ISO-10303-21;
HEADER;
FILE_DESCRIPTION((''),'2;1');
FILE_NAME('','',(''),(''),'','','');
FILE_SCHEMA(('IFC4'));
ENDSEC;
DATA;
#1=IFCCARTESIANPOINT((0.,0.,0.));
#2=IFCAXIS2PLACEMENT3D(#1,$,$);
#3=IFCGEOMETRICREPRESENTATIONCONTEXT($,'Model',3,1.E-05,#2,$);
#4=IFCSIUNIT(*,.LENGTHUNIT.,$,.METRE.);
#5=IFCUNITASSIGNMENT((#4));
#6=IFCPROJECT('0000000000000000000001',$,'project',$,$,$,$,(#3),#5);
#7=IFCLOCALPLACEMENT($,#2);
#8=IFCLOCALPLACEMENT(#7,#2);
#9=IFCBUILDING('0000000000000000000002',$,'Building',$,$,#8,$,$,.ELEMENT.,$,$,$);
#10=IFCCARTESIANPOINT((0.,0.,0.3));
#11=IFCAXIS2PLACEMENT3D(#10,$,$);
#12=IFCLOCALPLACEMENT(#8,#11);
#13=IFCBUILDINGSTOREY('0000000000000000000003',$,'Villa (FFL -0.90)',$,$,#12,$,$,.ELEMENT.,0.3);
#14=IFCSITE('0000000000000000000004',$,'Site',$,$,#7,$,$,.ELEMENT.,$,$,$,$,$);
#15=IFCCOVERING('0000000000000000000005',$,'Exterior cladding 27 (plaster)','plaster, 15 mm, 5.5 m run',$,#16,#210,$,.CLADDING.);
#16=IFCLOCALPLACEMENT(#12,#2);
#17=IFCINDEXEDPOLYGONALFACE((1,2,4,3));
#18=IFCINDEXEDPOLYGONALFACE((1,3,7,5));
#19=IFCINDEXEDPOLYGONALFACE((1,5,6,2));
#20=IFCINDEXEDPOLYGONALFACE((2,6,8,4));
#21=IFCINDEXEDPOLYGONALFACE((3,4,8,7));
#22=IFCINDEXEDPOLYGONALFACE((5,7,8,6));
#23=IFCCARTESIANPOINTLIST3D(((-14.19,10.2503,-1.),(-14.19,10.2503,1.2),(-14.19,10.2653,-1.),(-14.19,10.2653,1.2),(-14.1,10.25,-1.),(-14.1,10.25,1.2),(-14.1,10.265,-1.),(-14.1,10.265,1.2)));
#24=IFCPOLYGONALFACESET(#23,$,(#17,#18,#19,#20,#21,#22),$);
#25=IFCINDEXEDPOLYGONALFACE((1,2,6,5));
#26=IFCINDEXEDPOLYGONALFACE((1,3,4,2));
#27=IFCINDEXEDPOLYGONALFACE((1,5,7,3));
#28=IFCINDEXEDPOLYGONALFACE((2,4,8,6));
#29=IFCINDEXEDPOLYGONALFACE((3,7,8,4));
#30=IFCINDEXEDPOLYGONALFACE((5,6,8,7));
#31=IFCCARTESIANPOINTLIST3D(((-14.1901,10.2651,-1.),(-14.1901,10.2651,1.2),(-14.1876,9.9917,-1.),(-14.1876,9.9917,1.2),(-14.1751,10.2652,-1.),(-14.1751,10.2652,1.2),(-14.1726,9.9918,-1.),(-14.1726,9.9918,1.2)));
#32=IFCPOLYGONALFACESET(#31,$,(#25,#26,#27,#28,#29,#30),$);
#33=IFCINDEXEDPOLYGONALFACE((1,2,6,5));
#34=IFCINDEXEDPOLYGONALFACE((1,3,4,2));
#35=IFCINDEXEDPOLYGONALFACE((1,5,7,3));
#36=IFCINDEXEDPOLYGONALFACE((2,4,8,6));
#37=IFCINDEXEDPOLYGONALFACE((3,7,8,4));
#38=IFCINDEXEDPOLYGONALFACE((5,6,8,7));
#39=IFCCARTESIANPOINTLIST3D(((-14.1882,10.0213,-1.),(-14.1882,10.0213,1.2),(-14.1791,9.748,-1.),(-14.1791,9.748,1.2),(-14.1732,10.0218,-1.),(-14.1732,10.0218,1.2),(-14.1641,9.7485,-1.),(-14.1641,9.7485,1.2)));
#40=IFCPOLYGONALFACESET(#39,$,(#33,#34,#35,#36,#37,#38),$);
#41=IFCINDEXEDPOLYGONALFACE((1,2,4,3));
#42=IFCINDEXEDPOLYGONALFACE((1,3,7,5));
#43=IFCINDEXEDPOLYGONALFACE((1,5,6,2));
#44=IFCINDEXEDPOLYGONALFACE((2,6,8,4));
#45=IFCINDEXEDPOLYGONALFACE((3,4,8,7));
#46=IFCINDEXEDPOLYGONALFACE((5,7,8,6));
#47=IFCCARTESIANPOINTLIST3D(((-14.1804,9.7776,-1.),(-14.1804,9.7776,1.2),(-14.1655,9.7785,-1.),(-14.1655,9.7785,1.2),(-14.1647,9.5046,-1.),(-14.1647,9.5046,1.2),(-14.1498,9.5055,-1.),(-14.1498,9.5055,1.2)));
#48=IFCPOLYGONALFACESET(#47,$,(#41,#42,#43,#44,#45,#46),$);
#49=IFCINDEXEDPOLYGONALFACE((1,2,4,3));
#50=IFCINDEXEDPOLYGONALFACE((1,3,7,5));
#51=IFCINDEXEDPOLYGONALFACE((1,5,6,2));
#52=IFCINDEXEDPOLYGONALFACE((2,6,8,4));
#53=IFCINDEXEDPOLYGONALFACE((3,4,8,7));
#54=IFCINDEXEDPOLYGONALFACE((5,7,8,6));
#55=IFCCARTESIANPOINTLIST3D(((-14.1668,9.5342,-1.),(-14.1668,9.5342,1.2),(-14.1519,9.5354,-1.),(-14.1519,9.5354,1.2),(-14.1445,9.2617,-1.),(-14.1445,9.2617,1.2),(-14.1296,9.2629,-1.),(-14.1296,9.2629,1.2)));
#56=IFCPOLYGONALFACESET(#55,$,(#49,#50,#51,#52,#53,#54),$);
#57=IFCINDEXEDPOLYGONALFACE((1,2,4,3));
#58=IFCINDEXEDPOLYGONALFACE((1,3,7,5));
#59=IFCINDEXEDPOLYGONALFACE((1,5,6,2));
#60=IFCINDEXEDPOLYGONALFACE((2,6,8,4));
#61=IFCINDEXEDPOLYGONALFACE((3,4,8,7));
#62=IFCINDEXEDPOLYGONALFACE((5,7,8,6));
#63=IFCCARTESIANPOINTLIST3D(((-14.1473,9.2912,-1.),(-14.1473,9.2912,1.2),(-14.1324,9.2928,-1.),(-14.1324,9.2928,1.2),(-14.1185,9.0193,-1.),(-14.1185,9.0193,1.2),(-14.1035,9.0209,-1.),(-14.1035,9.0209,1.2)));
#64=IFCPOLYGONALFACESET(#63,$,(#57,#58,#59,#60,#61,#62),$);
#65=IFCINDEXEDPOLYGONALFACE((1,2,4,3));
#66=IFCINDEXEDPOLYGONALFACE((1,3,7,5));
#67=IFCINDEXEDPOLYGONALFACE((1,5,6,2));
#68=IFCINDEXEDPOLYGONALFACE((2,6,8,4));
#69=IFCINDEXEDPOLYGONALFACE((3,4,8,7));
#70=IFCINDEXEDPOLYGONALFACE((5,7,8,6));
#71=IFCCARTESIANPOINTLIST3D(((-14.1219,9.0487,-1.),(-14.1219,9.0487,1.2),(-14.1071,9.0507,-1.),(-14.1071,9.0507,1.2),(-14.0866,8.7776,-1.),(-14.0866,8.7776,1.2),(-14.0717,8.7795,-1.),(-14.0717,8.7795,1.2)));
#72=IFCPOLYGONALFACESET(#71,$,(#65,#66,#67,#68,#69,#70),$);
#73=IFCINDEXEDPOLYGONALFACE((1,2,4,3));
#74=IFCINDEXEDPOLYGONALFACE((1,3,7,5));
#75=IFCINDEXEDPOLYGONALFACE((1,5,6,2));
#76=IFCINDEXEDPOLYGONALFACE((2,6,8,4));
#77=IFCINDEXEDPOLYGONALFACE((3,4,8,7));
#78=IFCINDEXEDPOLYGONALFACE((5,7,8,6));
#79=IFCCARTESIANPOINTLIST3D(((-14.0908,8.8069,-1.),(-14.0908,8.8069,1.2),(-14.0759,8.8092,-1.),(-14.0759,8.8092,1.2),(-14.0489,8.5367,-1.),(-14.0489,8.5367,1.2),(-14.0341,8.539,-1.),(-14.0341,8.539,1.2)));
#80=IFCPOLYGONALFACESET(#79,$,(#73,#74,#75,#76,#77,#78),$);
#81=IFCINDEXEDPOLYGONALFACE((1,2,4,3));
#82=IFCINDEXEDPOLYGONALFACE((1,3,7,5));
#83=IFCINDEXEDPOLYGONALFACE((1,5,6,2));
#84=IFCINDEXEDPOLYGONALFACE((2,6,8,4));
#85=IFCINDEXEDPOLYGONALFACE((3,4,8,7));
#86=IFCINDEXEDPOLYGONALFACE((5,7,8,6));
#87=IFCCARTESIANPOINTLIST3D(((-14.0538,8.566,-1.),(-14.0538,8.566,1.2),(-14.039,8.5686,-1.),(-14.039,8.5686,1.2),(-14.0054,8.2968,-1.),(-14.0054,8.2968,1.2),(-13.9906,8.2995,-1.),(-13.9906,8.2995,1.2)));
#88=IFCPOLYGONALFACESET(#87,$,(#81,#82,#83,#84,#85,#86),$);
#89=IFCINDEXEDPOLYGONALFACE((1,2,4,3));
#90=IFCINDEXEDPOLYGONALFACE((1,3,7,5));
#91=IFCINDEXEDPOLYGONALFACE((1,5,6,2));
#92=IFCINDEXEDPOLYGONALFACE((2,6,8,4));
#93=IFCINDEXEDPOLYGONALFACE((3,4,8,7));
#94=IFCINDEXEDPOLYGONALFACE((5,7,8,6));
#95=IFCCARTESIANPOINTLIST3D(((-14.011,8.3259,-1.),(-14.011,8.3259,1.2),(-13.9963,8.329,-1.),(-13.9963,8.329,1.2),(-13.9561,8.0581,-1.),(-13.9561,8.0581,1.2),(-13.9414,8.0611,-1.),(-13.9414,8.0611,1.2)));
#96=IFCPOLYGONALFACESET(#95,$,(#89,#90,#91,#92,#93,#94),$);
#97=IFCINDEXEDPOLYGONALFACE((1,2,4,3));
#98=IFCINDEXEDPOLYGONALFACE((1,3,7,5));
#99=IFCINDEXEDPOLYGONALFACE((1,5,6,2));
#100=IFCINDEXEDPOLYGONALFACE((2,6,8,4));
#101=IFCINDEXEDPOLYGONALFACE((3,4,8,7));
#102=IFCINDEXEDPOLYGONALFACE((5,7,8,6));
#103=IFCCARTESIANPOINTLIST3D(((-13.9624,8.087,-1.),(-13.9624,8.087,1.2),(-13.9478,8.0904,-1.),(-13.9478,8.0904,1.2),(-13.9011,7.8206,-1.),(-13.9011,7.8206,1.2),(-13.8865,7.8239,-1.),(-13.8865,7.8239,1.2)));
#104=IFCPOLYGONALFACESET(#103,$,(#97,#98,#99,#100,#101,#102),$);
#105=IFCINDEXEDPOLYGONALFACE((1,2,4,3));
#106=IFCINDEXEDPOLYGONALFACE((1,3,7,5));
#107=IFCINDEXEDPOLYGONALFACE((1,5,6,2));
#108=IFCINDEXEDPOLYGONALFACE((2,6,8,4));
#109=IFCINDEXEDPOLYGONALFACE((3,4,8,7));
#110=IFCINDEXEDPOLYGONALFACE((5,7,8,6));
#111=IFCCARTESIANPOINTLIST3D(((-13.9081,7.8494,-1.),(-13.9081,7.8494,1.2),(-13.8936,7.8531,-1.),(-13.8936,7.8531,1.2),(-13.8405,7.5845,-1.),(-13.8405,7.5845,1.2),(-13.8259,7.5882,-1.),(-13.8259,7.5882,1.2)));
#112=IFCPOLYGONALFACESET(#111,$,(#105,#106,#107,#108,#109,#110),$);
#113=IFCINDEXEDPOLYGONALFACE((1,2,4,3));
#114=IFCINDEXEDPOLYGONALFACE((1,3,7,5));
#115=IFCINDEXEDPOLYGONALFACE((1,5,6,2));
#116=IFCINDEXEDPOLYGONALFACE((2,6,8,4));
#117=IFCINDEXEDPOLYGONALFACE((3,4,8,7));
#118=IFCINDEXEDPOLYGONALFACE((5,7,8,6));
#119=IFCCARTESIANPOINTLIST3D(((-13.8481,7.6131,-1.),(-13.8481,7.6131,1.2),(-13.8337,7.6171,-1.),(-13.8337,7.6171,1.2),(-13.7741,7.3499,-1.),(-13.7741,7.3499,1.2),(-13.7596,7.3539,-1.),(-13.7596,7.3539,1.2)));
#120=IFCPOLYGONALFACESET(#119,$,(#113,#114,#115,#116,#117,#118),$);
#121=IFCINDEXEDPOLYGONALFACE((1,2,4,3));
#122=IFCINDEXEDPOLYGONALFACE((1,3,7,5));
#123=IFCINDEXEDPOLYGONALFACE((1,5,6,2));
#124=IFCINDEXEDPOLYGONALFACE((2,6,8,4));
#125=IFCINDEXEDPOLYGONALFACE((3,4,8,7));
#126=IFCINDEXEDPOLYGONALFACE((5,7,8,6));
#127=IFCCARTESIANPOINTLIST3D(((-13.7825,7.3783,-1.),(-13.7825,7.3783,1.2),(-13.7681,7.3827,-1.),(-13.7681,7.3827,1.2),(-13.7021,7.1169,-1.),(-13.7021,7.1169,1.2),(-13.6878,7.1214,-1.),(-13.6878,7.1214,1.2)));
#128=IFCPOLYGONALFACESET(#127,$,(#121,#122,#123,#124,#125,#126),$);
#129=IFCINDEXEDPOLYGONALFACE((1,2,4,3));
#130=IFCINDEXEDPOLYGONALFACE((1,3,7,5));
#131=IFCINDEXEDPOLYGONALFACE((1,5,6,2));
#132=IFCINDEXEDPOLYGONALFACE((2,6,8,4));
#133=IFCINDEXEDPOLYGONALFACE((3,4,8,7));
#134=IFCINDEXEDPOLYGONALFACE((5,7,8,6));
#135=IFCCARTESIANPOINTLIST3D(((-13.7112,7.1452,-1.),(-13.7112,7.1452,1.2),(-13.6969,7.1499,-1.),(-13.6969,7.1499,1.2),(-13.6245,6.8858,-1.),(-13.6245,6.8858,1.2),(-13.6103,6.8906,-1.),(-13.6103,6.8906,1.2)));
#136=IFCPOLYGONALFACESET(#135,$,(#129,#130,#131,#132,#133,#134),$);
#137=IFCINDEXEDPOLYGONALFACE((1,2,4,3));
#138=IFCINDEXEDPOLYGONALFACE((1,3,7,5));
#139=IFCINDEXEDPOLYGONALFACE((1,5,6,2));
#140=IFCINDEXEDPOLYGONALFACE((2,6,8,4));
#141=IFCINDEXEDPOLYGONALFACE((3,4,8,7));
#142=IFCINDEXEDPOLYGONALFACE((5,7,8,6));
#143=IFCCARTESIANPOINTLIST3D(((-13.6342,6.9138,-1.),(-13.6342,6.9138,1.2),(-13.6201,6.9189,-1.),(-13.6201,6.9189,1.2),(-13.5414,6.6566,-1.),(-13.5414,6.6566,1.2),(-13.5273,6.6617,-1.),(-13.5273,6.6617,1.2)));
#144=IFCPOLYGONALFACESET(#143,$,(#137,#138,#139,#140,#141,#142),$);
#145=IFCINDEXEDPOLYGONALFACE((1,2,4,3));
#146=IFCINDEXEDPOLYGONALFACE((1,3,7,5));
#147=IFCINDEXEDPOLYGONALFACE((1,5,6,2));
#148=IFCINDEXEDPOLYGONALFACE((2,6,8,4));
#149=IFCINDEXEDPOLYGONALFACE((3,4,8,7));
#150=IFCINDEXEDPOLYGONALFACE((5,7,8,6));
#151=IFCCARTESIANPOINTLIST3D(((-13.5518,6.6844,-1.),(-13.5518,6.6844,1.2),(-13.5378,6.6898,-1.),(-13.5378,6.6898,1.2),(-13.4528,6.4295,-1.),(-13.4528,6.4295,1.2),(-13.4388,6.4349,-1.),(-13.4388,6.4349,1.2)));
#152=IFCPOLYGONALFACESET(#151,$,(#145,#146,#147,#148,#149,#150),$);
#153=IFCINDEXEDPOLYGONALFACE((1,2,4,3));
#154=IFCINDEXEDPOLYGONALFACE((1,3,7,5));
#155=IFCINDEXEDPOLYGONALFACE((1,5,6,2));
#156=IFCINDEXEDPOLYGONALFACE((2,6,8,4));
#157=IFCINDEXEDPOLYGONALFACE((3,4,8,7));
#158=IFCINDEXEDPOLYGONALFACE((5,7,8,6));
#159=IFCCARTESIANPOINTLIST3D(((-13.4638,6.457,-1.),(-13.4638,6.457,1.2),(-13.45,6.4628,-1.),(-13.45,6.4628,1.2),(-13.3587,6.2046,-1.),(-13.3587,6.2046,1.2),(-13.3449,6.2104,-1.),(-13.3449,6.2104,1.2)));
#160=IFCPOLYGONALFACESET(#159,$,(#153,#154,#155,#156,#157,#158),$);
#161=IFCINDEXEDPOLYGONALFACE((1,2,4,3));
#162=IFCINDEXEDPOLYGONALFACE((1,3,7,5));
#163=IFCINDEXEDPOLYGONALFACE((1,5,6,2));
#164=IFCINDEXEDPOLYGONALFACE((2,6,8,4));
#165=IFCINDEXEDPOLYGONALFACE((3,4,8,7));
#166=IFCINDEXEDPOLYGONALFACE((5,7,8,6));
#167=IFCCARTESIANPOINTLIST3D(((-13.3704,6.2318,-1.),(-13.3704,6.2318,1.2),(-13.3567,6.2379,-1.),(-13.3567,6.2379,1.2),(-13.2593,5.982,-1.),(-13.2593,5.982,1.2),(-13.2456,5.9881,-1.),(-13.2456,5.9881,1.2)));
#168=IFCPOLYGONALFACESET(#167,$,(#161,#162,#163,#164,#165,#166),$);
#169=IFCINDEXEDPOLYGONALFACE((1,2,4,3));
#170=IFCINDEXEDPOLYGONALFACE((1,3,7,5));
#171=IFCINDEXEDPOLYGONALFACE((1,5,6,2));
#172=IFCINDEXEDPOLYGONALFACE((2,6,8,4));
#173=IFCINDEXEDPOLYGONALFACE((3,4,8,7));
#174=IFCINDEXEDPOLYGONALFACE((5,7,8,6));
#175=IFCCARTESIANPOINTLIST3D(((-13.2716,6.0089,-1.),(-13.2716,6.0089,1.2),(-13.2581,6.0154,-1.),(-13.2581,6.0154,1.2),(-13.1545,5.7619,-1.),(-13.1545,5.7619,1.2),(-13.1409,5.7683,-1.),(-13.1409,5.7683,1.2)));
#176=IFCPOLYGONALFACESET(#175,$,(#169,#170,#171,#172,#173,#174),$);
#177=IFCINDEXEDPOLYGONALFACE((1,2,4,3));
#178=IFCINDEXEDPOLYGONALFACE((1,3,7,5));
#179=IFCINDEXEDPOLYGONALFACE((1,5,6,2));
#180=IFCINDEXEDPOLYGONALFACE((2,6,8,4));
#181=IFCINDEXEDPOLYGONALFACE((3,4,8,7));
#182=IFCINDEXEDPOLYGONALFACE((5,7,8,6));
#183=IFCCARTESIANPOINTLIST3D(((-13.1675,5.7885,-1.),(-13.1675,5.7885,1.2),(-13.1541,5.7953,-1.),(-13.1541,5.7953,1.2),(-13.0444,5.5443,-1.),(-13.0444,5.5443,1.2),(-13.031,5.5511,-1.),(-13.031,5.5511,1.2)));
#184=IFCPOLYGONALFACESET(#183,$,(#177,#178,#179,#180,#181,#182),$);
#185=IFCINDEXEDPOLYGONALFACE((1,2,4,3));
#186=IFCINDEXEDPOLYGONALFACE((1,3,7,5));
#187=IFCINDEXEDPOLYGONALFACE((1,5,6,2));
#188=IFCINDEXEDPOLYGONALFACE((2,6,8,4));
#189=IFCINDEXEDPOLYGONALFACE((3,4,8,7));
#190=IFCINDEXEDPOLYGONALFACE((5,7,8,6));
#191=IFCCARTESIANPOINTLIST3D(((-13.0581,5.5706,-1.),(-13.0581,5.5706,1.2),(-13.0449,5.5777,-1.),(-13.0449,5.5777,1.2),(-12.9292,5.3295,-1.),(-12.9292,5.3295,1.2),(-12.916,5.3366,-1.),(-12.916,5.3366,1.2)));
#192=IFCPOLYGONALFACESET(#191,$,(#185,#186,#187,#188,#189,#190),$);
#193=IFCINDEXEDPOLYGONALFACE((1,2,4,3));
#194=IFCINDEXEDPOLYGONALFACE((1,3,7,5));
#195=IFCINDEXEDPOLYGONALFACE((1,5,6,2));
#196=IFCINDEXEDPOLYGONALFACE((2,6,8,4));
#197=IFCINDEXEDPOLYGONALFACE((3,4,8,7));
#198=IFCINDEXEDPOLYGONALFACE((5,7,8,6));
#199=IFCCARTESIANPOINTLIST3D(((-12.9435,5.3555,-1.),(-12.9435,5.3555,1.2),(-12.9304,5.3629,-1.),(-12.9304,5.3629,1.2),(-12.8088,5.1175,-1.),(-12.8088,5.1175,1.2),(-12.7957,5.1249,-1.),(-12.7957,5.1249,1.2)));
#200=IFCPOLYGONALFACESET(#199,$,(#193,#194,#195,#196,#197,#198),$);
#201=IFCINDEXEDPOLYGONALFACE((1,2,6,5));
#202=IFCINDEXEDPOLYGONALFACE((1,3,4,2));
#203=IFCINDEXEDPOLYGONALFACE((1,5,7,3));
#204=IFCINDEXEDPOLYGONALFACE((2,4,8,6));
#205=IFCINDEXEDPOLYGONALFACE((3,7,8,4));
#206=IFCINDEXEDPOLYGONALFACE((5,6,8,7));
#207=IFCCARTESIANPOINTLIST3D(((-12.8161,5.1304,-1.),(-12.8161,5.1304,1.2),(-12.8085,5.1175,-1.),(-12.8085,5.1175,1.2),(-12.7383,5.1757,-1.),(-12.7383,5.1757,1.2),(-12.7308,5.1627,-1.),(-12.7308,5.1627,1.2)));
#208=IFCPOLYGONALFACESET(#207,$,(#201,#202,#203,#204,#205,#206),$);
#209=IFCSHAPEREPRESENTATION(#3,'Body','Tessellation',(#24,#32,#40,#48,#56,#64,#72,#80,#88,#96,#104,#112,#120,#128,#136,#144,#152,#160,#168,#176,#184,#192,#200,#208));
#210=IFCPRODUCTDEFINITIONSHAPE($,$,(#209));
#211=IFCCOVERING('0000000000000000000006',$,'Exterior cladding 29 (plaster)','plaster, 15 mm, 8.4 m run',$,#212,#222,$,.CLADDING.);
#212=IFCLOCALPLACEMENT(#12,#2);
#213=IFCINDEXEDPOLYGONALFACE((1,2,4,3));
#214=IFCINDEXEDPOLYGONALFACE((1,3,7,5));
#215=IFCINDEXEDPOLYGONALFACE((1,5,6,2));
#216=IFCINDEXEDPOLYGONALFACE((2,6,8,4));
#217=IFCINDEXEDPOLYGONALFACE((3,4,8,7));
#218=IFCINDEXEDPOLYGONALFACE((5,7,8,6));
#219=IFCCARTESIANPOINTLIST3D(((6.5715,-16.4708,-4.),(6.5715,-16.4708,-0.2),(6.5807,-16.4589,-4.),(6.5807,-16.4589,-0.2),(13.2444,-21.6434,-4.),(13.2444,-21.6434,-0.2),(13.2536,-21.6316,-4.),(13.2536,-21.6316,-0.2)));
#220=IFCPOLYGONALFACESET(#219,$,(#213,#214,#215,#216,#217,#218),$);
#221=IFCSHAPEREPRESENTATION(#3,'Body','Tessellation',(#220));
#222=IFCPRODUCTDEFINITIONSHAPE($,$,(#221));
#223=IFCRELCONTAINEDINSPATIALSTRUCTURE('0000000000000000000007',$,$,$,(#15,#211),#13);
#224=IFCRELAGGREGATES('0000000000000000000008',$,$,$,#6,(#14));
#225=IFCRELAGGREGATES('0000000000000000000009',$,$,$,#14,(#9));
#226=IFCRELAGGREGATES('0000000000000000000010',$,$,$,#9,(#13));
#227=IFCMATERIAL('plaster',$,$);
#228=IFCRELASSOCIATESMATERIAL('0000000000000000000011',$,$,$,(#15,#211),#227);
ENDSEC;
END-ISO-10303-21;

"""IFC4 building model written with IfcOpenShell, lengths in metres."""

from ifc_helpers import new_model, si_unit, frame, origin, origin_with_axes, place, context, project, spatial, polyline, outline, extrude, material, element, save


model = new_model("IFC4")

# Units and contexts
model_context = context("Model", 3, precision=1e-05, world=origin())
ifc_project = project(units=[si_unit("LENGTHUNIT", "METRE")], contexts=[model_context])

# Site, building, storey
site_placement = place(None, origin())
site = spatial("IfcSite", under=ifc_project, at=site_placement, Name="Site", CompositionType="ELEMENT")
building_placement = place(site_placement, origin())
building = spatial("IfcBuilding", under=site, at=building_placement, Name="Building", CompositionType="ELEMENT")
storey_placement = place(building_placement, frame((0.0, 0.0, 0.3)))
storey = spatial("IfcBuildingStorey", under=building, at=storey_placement, Name="Villa (FFL -0.90)", CompositionType="ELEMENT", Elevation=0.3)

# Coverings
ifc_material = material(Name="plaster")
covering_1_placement = place(storey_placement, origin_with_axes())
element("IfcCovering", 1, at=covering_1_placement, inside=storey, material=ifc_material, Name="Exterior cladding 27 (plaster)", Description="plaster, 15 mm, 5.5 m run", PredefinedType="CLADDING", context=model_context, shape_type="SweptSolid", body=[
    extrude(outline(polyline([(-14.1, 10.265), (-14.19, 10.2653), (-14.19, 10.2503), (-14.1, 10.25), (-14.1, 10.265)])), frame((0.0, 0.0, -1.0)), (0.0, 0.0, 1.0), 2.2),
    extrude(outline(polyline([(-14.1901, 10.2651), (-14.1876, 9.9917), (-14.1726, 9.9918), (-14.1751, 10.2652), (-14.1901, 10.2651)])), frame((0.0, 0.0, -1.0)), (0.0, 0.0, 1.0), 2.2),
    extrude(outline(polyline([(-14.1882, 10.0213), (-14.1791, 9.748), (-14.1641, 9.7485), (-14.1732, 10.0218), (-14.1882, 10.0213)])), frame((0.0, 0.0, -1.0)), (0.0, 0.0, 1.0), 2.2),
    extrude(outline(polyline([(-14.1804, 9.7776), (-14.1647, 9.5046), (-14.1498, 9.5055), (-14.1655, 9.7785), (-14.1804, 9.7776)])), frame((0.0, 0.0, -1.0)), (0.0, 0.0, 1.0), 2.2),
    extrude(outline(polyline([(-14.1668, 9.5342), (-14.1445, 9.2617), (-14.1296, 9.2629), (-14.1519, 9.5354), (-14.1668, 9.5342)])), frame((0.0, 0.0, -1.0)), (0.0, 0.0, 1.0), 2.2),
    extrude(outline(polyline([(-14.1473, 9.2912), (-14.1185, 9.0193), (-14.1035, 9.0209), (-14.1324, 9.2928), (-14.1473, 9.2912)])), frame((0.0, 0.0, -1.0)), (0.0, 0.0, 1.0), 2.2),
    extrude(outline(polyline([(-14.1219, 9.0487), (-14.0866, 8.7776), (-14.0717, 8.7795), (-14.1071, 9.0507), (-14.1219, 9.0487)])), frame((0.0, 0.0, -1.0)), (0.0, 0.0, 1.0), 2.2),
    extrude(outline(polyline([(-14.0908, 8.8069), (-14.0489, 8.5367), (-14.0341, 8.539), (-14.0759, 8.8092), (-14.0908, 8.8069)])), frame((0.0, 0.0, -1.0)), (0.0, 0.0, 1.0), 2.2),
    extrude(outline(polyline([(-14.0538, 8.566), (-14.0054, 8.2968), (-13.9906, 8.2995), (-14.039, 8.5686), (-14.0538, 8.566)])), frame((0.0, 0.0, -1.0)), (0.0, 0.0, 1.0), 2.2),
    extrude(outline(polyline([(-14.011, 8.3259), (-13.9561, 8.0581), (-13.9414, 8.0611), (-13.9963, 8.329), (-14.011, 8.3259)])), frame((0.0, 0.0, -1.0)), (0.0, 0.0, 1.0), 2.2),
    extrude(outline(polyline([(-13.9624, 8.087), (-13.9011, 7.8206), (-13.8865, 7.8239), (-13.9478, 8.0904), (-13.9624, 8.087)])), frame((0.0, 0.0, -1.0)), (0.0, 0.0, 1.0), 2.2),
    extrude(outline(polyline([(-13.9081, 7.8494), (-13.8405, 7.5845), (-13.8259, 7.5882), (-13.8936, 7.8531), (-13.9081, 7.8494)])), frame((0.0, 0.0, -1.0)), (0.0, 0.0, 1.0), 2.2),
    extrude(outline(polyline([(-13.8481, 7.6131), (-13.7741, 7.3499), (-13.7596, 7.3539), (-13.8337, 7.6171), (-13.8481, 7.6131)])), frame((0.0, 0.0, -1.0)), (0.0, 0.0, 1.0), 2.2),
    extrude(outline(polyline([(-13.7825, 7.3783), (-13.7021, 7.1169), (-13.6878, 7.1214), (-13.7681, 7.3827), (-13.7825, 7.3783)])), frame((0.0, 0.0, -1.0)), (0.0, 0.0, 1.0), 2.2),
    extrude(outline(polyline([(-13.7111, 7.1452), (-13.6245, 6.8858), (-13.6103, 6.8906), (-13.6969, 7.1499), (-13.7111, 7.1452)])), frame((0.0, 0.0, -1.0)), (0.0, 0.0, 1.0), 2.2),
    extrude(outline(polyline([(-13.6342, 6.9138), (-13.5414, 6.6566), (-13.5273, 6.6617), (-13.6201, 6.9189), (-13.6342, 6.9138)])), frame((0.0, 0.0, -1.0)), (0.0, 0.0, 1.0), 2.2),
    extrude(outline(polyline([(-13.5518, 6.6844), (-13.4528, 6.4295), (-13.4388, 6.4349), (-13.5378, 6.6898), (-13.5518, 6.6844)])), frame((0.0, 0.0, -1.0)), (0.0, 0.0, 1.0), 2.2),
    extrude(outline(polyline([(-13.4638, 6.457), (-13.3587, 6.2046), (-13.3449, 6.2104), (-13.45, 6.4628), (-13.4638, 6.457)])), frame((0.0, 0.0, -1.0)), (0.0, 0.0, 1.0), 2.2),
    extrude(outline(polyline([(-13.3704, 6.2318), (-13.2593, 5.982), (-13.2456, 5.9881), (-13.3567, 6.2379), (-13.3704, 6.2318)])), frame((0.0, 0.0, -1.0)), (0.0, 0.0, 1.0), 2.2),
    extrude(outline(polyline([(-13.2716, 6.0089), (-13.1545, 5.7619), (-13.1409, 5.7683), (-13.2581, 6.0154), (-13.2716, 6.0089)])), frame((0.0, 0.0, -1.0)), (0.0, 0.0, 1.0), 2.2),
    extrude(outline(polyline([(-13.1675, 5.7885), (-13.0444, 5.5443), (-13.031, 5.5511), (-13.1541, 5.7953), (-13.1675, 5.7885)])), frame((0.0, 0.0, -1.0)), (0.0, 0.0, 1.0), 2.2),
    extrude(outline(polyline([(-13.0581, 5.5706), (-12.9292, 5.3295), (-12.916, 5.3366), (-13.0449, 5.5777), (-13.0581, 5.5706)])), frame((0.0, 0.0, -1.0)), (0.0, 0.0, 1.0), 2.2),
    extrude(outline(polyline([(-12.9435, 5.3555), (-12.8088, 5.1175), (-12.7957, 5.1249), (-12.9304, 5.3629), (-12.9435, 5.3555)])), frame((0.0, 0.0, -1.0)), (0.0, 0.0, 1.0), 2.2),
    extrude(outline(polyline([(-12.8085, 5.1175), (-12.7308, 5.1627), (-12.7383, 5.1757), (-12.8161, 5.1304), (-12.8085, 5.1175)])), frame((0.0, 0.0, -1.0)), (0.0, 0.0, 1.0), 2.2),
])
covering_2_placement = place(storey_placement, origin_with_axes())
element("IfcCovering", 2, at=covering_2_placement, inside=storey, material=ifc_material, Name="Exterior cladding 29 (plaster)", Description="plaster, 15 mm, 8.4 m run", PredefinedType="CLADDING", context=model_context, shape_type="SweptSolid", body=[
    extrude(outline(polyline([(6.5715, -16.4708), (13.2444, -21.6434), (13.2536, -21.6316), (6.5807, -16.4589), (6.5715, -16.4708)])), frame((0.0, 0.0, -4.0)), (0.0, 0.0, 1.0), 3.8),
])

save(model, "model.ifc")
